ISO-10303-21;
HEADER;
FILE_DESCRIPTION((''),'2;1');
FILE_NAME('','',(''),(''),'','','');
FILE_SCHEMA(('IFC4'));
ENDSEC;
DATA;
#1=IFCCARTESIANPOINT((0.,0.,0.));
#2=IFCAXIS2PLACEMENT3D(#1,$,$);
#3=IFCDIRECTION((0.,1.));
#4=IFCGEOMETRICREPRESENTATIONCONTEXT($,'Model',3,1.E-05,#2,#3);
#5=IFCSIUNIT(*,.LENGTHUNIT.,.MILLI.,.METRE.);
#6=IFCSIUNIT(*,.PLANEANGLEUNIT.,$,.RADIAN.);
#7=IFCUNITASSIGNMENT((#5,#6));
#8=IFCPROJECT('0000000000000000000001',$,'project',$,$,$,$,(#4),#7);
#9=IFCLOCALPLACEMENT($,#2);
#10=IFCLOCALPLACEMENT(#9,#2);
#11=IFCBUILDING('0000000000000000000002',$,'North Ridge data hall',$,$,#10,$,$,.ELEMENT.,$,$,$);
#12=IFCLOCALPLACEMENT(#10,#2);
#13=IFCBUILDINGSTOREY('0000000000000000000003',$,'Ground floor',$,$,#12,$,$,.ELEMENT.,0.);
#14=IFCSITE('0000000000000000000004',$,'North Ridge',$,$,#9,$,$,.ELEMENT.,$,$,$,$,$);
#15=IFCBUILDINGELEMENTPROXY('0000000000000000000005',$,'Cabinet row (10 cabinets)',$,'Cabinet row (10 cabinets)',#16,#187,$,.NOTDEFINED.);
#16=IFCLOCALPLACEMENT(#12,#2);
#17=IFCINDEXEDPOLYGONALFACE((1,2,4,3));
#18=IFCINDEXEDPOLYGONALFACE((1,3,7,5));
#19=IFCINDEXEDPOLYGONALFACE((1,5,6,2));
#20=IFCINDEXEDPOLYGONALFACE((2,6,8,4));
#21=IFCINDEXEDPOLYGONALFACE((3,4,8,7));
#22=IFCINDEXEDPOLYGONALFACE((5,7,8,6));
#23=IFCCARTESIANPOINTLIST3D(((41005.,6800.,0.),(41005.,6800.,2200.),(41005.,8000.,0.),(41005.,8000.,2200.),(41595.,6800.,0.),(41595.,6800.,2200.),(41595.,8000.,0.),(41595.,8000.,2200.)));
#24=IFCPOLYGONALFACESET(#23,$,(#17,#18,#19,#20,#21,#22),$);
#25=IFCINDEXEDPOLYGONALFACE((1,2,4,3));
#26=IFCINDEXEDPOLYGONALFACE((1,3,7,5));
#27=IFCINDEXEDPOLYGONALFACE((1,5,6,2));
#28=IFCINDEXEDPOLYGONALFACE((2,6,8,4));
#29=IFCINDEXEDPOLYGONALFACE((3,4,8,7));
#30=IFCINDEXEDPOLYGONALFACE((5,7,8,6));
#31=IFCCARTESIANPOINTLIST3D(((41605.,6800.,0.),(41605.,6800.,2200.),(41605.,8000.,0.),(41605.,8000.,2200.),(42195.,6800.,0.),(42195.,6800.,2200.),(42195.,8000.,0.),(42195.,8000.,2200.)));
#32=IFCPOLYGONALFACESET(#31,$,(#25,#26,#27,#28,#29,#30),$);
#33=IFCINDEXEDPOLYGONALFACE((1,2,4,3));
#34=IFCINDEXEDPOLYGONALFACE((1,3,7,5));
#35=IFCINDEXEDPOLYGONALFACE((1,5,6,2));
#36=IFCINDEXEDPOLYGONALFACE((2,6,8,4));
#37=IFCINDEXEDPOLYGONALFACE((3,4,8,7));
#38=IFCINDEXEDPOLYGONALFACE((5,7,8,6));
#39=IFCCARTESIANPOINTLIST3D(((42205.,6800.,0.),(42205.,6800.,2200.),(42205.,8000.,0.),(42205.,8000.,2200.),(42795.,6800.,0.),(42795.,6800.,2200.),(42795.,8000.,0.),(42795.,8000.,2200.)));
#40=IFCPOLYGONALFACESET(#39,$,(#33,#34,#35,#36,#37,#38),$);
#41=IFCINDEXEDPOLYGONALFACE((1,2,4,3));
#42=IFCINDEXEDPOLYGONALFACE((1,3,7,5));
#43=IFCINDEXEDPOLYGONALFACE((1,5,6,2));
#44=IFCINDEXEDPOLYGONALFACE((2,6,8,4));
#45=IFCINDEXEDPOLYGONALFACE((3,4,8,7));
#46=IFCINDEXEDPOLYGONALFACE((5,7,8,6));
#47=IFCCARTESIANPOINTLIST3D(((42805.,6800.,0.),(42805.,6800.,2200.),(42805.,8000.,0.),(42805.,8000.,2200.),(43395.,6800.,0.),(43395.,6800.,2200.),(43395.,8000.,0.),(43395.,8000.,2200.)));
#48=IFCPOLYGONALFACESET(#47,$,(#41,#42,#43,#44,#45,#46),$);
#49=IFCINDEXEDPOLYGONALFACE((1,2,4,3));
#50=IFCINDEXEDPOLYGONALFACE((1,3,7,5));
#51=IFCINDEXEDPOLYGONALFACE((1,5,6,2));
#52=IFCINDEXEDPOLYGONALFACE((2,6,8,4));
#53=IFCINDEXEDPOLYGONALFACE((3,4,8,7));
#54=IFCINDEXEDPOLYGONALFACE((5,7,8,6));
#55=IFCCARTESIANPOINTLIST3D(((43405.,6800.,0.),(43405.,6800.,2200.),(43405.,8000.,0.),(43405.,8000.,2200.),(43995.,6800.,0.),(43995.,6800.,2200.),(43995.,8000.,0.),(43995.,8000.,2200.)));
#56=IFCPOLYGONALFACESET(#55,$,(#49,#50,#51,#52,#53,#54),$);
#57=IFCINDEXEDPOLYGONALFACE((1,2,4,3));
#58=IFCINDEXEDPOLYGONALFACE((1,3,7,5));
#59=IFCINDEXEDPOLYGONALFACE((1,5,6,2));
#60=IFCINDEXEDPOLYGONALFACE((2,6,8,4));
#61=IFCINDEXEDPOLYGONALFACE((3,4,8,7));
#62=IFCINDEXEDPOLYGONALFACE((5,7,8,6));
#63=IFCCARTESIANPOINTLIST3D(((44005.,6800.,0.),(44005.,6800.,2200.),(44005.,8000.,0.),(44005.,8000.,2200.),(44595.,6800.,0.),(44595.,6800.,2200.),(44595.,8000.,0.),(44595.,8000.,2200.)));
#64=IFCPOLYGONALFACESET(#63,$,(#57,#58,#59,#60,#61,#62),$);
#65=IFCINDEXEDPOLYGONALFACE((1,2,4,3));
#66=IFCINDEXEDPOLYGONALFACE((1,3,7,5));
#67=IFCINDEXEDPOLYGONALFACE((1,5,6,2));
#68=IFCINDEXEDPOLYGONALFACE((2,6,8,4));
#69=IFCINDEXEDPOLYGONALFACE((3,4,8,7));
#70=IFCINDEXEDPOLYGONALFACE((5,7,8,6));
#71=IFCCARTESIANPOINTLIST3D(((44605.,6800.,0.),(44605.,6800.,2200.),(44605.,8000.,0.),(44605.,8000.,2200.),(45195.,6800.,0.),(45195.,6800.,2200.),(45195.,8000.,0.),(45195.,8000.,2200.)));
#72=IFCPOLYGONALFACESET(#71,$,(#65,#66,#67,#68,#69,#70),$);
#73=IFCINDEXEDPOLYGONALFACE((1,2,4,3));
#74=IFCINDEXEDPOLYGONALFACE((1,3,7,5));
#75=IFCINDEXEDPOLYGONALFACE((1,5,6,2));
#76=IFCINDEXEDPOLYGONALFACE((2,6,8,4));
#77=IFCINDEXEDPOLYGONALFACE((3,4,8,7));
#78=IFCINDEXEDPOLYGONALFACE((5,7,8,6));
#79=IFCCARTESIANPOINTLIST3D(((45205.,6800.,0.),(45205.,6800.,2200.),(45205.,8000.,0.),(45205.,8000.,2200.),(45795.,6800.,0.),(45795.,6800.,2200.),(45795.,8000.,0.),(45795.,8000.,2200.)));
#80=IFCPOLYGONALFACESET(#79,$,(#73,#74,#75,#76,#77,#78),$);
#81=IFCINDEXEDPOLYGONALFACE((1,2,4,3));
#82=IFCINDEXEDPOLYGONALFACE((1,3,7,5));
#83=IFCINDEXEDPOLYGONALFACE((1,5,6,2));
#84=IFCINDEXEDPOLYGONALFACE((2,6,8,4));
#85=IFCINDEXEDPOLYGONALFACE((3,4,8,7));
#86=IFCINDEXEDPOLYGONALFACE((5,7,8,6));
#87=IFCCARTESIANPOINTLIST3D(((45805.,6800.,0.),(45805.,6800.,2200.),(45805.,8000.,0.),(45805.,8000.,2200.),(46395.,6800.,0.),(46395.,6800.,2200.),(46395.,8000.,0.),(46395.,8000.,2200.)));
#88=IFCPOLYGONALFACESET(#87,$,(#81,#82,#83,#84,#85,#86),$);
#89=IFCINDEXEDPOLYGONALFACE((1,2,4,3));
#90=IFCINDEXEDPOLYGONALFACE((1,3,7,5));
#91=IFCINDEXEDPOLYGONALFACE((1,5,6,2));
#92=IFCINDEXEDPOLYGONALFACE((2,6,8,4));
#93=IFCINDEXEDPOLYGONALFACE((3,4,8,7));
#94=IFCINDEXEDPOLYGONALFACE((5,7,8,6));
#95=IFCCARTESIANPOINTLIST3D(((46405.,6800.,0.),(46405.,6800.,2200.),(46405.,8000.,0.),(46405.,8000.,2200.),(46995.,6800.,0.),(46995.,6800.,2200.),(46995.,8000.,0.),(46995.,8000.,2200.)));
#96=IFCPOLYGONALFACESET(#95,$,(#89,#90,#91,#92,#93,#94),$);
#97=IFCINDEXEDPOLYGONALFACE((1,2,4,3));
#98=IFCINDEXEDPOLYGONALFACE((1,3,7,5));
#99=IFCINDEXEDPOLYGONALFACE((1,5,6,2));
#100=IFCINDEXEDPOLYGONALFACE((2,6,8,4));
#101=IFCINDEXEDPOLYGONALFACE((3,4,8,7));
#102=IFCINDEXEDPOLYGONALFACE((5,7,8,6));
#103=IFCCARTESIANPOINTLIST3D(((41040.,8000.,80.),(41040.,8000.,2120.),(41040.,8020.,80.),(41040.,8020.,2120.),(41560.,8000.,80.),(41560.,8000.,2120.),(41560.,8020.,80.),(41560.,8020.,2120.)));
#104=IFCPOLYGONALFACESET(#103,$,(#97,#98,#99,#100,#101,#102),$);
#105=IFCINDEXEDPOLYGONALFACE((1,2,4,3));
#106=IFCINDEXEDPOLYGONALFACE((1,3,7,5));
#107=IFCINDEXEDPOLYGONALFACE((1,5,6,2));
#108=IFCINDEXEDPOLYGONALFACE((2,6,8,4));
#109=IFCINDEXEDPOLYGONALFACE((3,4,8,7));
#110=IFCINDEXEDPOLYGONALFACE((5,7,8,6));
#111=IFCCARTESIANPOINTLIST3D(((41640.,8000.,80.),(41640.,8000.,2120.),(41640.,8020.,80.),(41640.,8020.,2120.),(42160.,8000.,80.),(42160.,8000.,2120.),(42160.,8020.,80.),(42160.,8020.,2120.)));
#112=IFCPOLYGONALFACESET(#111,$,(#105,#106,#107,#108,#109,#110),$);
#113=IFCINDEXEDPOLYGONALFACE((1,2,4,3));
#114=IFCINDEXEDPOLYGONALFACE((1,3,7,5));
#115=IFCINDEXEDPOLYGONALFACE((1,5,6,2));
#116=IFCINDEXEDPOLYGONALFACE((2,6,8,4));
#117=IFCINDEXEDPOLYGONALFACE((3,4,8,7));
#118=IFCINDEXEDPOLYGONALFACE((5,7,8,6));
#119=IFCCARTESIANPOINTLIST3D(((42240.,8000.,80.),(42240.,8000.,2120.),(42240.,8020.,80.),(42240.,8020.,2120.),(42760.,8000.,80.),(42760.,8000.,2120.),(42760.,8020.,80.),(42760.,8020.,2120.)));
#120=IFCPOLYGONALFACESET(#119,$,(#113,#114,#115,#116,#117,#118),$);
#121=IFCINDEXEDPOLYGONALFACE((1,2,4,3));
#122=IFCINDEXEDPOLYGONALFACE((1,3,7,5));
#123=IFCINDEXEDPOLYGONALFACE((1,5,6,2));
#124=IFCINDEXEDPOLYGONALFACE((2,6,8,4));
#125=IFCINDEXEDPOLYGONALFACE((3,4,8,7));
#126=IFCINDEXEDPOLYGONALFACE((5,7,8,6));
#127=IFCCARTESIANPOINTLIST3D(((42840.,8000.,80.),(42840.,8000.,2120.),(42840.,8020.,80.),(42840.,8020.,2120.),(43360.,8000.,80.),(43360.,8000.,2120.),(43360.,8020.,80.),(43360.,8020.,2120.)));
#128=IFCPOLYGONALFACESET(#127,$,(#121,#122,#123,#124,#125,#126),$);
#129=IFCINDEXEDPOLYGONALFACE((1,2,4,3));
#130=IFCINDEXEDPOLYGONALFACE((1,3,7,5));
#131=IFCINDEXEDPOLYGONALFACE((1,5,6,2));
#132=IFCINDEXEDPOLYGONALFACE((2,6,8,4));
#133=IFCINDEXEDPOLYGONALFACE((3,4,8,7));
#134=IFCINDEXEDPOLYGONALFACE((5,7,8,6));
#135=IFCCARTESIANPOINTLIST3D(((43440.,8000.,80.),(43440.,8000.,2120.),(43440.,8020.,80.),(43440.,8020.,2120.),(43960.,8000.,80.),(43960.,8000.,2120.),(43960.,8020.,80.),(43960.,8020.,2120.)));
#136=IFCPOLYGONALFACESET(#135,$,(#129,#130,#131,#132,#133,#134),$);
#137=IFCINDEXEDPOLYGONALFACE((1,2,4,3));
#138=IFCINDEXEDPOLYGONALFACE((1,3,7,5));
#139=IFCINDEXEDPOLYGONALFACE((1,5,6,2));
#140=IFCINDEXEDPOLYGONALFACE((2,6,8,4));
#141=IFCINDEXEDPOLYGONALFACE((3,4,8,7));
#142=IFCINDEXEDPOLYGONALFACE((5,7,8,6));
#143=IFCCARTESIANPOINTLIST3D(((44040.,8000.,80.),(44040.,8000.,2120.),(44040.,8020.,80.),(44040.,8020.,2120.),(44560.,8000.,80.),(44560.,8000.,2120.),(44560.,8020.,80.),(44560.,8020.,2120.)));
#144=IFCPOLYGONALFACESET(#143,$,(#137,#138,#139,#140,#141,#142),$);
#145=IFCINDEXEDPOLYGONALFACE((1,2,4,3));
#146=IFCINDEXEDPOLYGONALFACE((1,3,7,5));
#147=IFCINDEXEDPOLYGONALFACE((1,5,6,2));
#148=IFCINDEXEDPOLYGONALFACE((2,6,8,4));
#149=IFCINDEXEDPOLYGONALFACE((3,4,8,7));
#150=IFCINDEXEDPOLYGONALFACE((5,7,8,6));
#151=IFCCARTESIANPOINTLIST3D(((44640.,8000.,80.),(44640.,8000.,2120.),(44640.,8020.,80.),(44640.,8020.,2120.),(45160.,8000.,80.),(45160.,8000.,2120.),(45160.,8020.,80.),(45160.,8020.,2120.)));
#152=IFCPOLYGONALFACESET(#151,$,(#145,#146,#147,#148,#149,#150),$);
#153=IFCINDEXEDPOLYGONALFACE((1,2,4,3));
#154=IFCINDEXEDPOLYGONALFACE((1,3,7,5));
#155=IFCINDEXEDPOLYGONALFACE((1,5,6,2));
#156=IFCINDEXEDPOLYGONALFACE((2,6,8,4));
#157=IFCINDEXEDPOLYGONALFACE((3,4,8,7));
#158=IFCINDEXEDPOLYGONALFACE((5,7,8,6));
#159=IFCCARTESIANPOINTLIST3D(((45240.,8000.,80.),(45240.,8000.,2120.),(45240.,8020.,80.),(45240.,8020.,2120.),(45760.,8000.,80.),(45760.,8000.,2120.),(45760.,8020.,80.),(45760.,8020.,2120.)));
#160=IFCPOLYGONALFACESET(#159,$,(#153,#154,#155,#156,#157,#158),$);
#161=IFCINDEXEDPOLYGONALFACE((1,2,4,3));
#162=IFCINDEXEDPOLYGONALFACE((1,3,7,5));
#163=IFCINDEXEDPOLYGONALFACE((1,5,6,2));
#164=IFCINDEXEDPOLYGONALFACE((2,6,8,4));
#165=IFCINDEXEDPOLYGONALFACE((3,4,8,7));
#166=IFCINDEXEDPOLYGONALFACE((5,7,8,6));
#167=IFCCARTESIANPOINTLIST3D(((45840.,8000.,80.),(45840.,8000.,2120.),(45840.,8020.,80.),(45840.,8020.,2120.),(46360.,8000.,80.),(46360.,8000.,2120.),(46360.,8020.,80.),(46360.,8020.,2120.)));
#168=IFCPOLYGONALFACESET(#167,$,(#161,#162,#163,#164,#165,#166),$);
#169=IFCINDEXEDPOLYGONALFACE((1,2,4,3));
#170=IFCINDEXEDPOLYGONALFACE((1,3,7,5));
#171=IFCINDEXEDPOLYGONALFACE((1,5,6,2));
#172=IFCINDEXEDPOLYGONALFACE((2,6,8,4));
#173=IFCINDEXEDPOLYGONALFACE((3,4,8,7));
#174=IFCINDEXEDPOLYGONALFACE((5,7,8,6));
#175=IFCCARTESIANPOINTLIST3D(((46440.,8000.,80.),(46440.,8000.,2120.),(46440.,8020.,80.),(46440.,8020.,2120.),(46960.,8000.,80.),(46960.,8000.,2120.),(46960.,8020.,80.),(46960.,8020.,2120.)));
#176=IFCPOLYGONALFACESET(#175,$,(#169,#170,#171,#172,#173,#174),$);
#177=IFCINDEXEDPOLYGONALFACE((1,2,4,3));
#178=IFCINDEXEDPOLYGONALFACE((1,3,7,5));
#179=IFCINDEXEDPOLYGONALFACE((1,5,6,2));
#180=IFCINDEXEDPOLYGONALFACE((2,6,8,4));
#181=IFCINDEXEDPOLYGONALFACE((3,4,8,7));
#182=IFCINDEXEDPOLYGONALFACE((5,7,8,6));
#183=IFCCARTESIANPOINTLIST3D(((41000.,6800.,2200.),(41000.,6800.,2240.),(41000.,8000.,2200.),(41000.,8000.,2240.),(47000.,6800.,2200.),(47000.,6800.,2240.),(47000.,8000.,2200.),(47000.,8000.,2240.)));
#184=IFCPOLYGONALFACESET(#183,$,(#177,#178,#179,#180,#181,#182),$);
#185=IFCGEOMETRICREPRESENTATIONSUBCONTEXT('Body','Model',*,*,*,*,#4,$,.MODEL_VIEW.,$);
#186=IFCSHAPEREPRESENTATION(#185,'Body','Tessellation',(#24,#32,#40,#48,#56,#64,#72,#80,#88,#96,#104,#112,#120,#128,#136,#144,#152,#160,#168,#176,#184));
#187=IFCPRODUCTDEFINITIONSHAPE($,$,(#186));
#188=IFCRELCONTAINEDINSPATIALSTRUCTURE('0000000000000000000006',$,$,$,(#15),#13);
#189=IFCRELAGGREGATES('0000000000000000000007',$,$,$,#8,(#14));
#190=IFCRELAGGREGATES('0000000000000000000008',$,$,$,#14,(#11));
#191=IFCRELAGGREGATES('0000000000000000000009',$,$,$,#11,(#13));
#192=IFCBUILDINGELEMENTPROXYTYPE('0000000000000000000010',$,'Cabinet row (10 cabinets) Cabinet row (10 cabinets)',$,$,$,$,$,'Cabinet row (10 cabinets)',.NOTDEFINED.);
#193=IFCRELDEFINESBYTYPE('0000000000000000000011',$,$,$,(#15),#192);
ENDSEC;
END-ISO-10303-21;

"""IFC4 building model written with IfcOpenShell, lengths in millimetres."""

from ifc_helpers import new_model, si_unit, direction, frame, origin, place, context, subcontext, project, spatial, polyline, outline, extrude, source, transform, mapped, type_object, type_shapes, element, save


model = new_model("IFC4")

# Units and contexts
model_context = context("Model", 3, precision=1e-05, world=origin(), true_north=direction((0.0, 1.0)))
body_context = subcontext(model_context, "Body", "Model", "MODEL_VIEW")
ifc_project = project(units=[si_unit("LENGTHUNIT", "METRE", prefix="MILLI"), si_unit("PLANEANGLEUNIT", "RADIAN")], contexts=[model_context])

# Site, building, storey
site_placement = place(None, origin())
site = spatial("IfcSite", under=ifc_project, at=site_placement, Name="North Ridge", CompositionType="ELEMENT")
building_placement = place(site_placement, origin())
building = spatial("IfcBuilding", under=site, at=building_placement, Name="North Ridge data hall", CompositionType="ELEMENT")
storey_placement = place(building_placement, origin())
storey = spatial("IfcBuildingStorey", under=building, at=storey_placement, Name="Ground floor", CompositionType="ELEMENT", Elevation=0.0)

# Building element proxy
building_element_proxy_type_1 = type_object("IfcBuildingElementProxyType", Name="Cabinet row (10 cabinets) Cabinet row (10 cabinets)", ElementType="Cabinet row (10 cabinets)", PredefinedType="NOTDEFINED")
shared_shape_1 = source(origin(), body_context, "Body", "SweptSolid", [
    extrude(outline(polyline([(5.0, 0.0), (595.0, 0.0), (595.0, 1200.0), (5.0, 1200.0), (5.0, 0.0)])), origin(), (0.0, 0.0, 1.0), 2200.0),
    extrude(outline(polyline([(605.0, 0.0), (1195.0, 0.0), (1195.0, 1200.0), (605.0, 1200.0), (605.0, 0.0)])), origin(), (0.0, 0.0, 1.0), 2200.0),
    extrude(outline(polyline([(1205.0, 0.0), (1795.0, 0.0), (1795.0, 1200.0), (1205.0, 1200.0), (1205.0, 0.0)])), origin(), (0.0, 0.0, 1.0), 2200.0),
    extrude(outline(polyline([(1805.0, 0.0), (2395.0, 0.0), (2395.0, 1200.0), (1805.0, 1200.0), (1805.0, 0.0)])), origin(), (0.0, 0.0, 1.0), 2200.0),
    extrude(outline(polyline([(2405.0, 0.0), (2995.0, 0.0), (2995.0, 1200.0), (2405.0, 1200.0), (2405.0, 0.0)])), origin(), (0.0, 0.0, 1.0), 2200.0),
    extrude(outline(polyline([(3005.0, 0.0), (3595.0, 0.0), (3595.0, 1200.0), (3005.0, 1200.0), (3005.0, 0.0)])), origin(), (0.0, 0.0, 1.0), 2200.0),
    extrude(outline(polyline([(3605.0, 0.0), (4195.0, 0.0), (4195.0, 1200.0), (3605.0, 1200.0), (3605.0, 0.0)])), origin(), (0.0, 0.0, 1.0), 2200.0),
    extrude(outline(polyline([(4205.0, 0.0), (4795.0, 0.0), (4795.0, 1200.0), (4205.0, 1200.0), (4205.0, 0.0)])), origin(), (0.0, 0.0, 1.0), 2200.0),
    extrude(outline(polyline([(4805.0, 0.0), (5395.0, 0.0), (5395.0, 1200.0), (4805.0, 1200.0), (4805.0, 0.0)])), origin(), (0.0, 0.0, 1.0), 2200.0),
    extrude(outline(polyline([(5405.0, 0.0), (5995.0, 0.0), (5995.0, 1200.0), (5405.0, 1200.0), (5405.0, 0.0)])), origin(), (0.0, 0.0, 1.0), 2200.0),
    extrude(outline(polyline([(40.0, 1200.0), (560.0, 1200.0), (560.0, 1220.0), (40.0, 1220.0), (40.0, 1200.0)])), frame((0.0, 0.0, 80.0)), (0.0, 0.0, 1.0), 2040.0),
    extrude(outline(polyline([(640.0, 1200.0), (1160.0, 1200.0), (1160.0, 1220.0), (640.0, 1220.0), (640.0, 1200.0)])), frame((0.0, 0.0, 80.0)), (0.0, 0.0, 1.0), 2040.0),
    extrude(outline(polyline([(1240.0, 1200.0), (1760.0, 1200.0), (1760.0, 1220.0), (1240.0, 1220.0), (1240.0, 1200.0)])), frame((0.0, 0.0, 80.0)), (0.0, 0.0, 1.0), 2040.0),
    extrude(outline(polyline([(1840.0, 1200.0), (2360.0, 1200.0), (2360.0, 1220.0), (1840.0, 1220.0), (1840.0, 1200.0)])), frame((0.0, 0.0, 80.0)), (0.0, 0.0, 1.0), 2040.0),
    extrude(outline(polyline([(2440.0, 1200.0), (2960.0, 1200.0), (2960.0, 1220.0), (2440.0, 1220.0), (2440.0, 1200.0)])), frame((0.0, 0.0, 80.0)), (0.0, 0.0, 1.0), 2040.0),
    extrude(outline(polyline([(3040.0, 1200.0), (3560.0, 1200.0), (3560.0, 1220.0), (3040.0, 1220.0), (3040.0, 1200.0)])), frame((0.0, 0.0, 80.0)), (0.0, 0.0, 1.0), 2040.0),
    extrude(outline(polyline([(3640.0, 1200.0), (4160.0, 1200.0), (4160.0, 1220.0), (3640.0, 1220.0), (3640.0, 1200.0)])), frame((0.0, 0.0, 80.0)), (0.0, 0.0, 1.0), 2040.0),
    extrude(outline(polyline([(4240.0, 1200.0), (4760.0, 1200.0), (4760.0, 1220.0), (4240.0, 1220.0), (4240.0, 1200.0)])), frame((0.0, 0.0, 80.0)), (0.0, 0.0, 1.0), 2040.0),
    extrude(outline(polyline([(4840.0, 1200.0), (5360.0, 1200.0), (5360.0, 1220.0), (4840.0, 1220.0), (4840.0, 1200.0)])), frame((0.0, 0.0, 80.0)), (0.0, 0.0, 1.0), 2040.0),
    extrude(outline(polyline([(5440.0, 1200.0), (5960.0, 1200.0), (5960.0, 1220.0), (5440.0, 1220.0), (5440.0, 1200.0)])), frame((0.0, 0.0, 80.0)), (0.0, 0.0, 1.0), 2040.0),
    extrude(outline(polyline([(0.0, 0.0), (6000.0, 0.0), (6000.0, 1200.0), (0.0, 1200.0), (0.0, 0.0)])), frame((0.0, 0.0, 2200.0)), (0.0, 0.0, 1.0), 40.0),
])
type_shapes(building_element_proxy_type_1, [shared_shape_1])
for number, where, z_axis, x_axis, name in (
    (1, (41000.0, 6800.0, 0.0), (0.0, 0.0, 1.0), (1.0, 0.0, 0.0), "Cabinet row (10 cabinets)"),
):
    element("IfcBuildingElementProxy", number, at=place(storey_placement, frame(where, z_axis=z_axis, x_axis=x_axis)), inside=storey, type_object=building_element_proxy_type_1, Name=name, ObjectType="Cabinet row (10 cabinets)", PredefinedType="NOTDEFINED", context=body_context, shape_type="MappedRepresentation", body=[
        mapped(shared_shape_1, transform((0.0, 0.0, 0.0))),
    ])

save(model, "model.ifc")
